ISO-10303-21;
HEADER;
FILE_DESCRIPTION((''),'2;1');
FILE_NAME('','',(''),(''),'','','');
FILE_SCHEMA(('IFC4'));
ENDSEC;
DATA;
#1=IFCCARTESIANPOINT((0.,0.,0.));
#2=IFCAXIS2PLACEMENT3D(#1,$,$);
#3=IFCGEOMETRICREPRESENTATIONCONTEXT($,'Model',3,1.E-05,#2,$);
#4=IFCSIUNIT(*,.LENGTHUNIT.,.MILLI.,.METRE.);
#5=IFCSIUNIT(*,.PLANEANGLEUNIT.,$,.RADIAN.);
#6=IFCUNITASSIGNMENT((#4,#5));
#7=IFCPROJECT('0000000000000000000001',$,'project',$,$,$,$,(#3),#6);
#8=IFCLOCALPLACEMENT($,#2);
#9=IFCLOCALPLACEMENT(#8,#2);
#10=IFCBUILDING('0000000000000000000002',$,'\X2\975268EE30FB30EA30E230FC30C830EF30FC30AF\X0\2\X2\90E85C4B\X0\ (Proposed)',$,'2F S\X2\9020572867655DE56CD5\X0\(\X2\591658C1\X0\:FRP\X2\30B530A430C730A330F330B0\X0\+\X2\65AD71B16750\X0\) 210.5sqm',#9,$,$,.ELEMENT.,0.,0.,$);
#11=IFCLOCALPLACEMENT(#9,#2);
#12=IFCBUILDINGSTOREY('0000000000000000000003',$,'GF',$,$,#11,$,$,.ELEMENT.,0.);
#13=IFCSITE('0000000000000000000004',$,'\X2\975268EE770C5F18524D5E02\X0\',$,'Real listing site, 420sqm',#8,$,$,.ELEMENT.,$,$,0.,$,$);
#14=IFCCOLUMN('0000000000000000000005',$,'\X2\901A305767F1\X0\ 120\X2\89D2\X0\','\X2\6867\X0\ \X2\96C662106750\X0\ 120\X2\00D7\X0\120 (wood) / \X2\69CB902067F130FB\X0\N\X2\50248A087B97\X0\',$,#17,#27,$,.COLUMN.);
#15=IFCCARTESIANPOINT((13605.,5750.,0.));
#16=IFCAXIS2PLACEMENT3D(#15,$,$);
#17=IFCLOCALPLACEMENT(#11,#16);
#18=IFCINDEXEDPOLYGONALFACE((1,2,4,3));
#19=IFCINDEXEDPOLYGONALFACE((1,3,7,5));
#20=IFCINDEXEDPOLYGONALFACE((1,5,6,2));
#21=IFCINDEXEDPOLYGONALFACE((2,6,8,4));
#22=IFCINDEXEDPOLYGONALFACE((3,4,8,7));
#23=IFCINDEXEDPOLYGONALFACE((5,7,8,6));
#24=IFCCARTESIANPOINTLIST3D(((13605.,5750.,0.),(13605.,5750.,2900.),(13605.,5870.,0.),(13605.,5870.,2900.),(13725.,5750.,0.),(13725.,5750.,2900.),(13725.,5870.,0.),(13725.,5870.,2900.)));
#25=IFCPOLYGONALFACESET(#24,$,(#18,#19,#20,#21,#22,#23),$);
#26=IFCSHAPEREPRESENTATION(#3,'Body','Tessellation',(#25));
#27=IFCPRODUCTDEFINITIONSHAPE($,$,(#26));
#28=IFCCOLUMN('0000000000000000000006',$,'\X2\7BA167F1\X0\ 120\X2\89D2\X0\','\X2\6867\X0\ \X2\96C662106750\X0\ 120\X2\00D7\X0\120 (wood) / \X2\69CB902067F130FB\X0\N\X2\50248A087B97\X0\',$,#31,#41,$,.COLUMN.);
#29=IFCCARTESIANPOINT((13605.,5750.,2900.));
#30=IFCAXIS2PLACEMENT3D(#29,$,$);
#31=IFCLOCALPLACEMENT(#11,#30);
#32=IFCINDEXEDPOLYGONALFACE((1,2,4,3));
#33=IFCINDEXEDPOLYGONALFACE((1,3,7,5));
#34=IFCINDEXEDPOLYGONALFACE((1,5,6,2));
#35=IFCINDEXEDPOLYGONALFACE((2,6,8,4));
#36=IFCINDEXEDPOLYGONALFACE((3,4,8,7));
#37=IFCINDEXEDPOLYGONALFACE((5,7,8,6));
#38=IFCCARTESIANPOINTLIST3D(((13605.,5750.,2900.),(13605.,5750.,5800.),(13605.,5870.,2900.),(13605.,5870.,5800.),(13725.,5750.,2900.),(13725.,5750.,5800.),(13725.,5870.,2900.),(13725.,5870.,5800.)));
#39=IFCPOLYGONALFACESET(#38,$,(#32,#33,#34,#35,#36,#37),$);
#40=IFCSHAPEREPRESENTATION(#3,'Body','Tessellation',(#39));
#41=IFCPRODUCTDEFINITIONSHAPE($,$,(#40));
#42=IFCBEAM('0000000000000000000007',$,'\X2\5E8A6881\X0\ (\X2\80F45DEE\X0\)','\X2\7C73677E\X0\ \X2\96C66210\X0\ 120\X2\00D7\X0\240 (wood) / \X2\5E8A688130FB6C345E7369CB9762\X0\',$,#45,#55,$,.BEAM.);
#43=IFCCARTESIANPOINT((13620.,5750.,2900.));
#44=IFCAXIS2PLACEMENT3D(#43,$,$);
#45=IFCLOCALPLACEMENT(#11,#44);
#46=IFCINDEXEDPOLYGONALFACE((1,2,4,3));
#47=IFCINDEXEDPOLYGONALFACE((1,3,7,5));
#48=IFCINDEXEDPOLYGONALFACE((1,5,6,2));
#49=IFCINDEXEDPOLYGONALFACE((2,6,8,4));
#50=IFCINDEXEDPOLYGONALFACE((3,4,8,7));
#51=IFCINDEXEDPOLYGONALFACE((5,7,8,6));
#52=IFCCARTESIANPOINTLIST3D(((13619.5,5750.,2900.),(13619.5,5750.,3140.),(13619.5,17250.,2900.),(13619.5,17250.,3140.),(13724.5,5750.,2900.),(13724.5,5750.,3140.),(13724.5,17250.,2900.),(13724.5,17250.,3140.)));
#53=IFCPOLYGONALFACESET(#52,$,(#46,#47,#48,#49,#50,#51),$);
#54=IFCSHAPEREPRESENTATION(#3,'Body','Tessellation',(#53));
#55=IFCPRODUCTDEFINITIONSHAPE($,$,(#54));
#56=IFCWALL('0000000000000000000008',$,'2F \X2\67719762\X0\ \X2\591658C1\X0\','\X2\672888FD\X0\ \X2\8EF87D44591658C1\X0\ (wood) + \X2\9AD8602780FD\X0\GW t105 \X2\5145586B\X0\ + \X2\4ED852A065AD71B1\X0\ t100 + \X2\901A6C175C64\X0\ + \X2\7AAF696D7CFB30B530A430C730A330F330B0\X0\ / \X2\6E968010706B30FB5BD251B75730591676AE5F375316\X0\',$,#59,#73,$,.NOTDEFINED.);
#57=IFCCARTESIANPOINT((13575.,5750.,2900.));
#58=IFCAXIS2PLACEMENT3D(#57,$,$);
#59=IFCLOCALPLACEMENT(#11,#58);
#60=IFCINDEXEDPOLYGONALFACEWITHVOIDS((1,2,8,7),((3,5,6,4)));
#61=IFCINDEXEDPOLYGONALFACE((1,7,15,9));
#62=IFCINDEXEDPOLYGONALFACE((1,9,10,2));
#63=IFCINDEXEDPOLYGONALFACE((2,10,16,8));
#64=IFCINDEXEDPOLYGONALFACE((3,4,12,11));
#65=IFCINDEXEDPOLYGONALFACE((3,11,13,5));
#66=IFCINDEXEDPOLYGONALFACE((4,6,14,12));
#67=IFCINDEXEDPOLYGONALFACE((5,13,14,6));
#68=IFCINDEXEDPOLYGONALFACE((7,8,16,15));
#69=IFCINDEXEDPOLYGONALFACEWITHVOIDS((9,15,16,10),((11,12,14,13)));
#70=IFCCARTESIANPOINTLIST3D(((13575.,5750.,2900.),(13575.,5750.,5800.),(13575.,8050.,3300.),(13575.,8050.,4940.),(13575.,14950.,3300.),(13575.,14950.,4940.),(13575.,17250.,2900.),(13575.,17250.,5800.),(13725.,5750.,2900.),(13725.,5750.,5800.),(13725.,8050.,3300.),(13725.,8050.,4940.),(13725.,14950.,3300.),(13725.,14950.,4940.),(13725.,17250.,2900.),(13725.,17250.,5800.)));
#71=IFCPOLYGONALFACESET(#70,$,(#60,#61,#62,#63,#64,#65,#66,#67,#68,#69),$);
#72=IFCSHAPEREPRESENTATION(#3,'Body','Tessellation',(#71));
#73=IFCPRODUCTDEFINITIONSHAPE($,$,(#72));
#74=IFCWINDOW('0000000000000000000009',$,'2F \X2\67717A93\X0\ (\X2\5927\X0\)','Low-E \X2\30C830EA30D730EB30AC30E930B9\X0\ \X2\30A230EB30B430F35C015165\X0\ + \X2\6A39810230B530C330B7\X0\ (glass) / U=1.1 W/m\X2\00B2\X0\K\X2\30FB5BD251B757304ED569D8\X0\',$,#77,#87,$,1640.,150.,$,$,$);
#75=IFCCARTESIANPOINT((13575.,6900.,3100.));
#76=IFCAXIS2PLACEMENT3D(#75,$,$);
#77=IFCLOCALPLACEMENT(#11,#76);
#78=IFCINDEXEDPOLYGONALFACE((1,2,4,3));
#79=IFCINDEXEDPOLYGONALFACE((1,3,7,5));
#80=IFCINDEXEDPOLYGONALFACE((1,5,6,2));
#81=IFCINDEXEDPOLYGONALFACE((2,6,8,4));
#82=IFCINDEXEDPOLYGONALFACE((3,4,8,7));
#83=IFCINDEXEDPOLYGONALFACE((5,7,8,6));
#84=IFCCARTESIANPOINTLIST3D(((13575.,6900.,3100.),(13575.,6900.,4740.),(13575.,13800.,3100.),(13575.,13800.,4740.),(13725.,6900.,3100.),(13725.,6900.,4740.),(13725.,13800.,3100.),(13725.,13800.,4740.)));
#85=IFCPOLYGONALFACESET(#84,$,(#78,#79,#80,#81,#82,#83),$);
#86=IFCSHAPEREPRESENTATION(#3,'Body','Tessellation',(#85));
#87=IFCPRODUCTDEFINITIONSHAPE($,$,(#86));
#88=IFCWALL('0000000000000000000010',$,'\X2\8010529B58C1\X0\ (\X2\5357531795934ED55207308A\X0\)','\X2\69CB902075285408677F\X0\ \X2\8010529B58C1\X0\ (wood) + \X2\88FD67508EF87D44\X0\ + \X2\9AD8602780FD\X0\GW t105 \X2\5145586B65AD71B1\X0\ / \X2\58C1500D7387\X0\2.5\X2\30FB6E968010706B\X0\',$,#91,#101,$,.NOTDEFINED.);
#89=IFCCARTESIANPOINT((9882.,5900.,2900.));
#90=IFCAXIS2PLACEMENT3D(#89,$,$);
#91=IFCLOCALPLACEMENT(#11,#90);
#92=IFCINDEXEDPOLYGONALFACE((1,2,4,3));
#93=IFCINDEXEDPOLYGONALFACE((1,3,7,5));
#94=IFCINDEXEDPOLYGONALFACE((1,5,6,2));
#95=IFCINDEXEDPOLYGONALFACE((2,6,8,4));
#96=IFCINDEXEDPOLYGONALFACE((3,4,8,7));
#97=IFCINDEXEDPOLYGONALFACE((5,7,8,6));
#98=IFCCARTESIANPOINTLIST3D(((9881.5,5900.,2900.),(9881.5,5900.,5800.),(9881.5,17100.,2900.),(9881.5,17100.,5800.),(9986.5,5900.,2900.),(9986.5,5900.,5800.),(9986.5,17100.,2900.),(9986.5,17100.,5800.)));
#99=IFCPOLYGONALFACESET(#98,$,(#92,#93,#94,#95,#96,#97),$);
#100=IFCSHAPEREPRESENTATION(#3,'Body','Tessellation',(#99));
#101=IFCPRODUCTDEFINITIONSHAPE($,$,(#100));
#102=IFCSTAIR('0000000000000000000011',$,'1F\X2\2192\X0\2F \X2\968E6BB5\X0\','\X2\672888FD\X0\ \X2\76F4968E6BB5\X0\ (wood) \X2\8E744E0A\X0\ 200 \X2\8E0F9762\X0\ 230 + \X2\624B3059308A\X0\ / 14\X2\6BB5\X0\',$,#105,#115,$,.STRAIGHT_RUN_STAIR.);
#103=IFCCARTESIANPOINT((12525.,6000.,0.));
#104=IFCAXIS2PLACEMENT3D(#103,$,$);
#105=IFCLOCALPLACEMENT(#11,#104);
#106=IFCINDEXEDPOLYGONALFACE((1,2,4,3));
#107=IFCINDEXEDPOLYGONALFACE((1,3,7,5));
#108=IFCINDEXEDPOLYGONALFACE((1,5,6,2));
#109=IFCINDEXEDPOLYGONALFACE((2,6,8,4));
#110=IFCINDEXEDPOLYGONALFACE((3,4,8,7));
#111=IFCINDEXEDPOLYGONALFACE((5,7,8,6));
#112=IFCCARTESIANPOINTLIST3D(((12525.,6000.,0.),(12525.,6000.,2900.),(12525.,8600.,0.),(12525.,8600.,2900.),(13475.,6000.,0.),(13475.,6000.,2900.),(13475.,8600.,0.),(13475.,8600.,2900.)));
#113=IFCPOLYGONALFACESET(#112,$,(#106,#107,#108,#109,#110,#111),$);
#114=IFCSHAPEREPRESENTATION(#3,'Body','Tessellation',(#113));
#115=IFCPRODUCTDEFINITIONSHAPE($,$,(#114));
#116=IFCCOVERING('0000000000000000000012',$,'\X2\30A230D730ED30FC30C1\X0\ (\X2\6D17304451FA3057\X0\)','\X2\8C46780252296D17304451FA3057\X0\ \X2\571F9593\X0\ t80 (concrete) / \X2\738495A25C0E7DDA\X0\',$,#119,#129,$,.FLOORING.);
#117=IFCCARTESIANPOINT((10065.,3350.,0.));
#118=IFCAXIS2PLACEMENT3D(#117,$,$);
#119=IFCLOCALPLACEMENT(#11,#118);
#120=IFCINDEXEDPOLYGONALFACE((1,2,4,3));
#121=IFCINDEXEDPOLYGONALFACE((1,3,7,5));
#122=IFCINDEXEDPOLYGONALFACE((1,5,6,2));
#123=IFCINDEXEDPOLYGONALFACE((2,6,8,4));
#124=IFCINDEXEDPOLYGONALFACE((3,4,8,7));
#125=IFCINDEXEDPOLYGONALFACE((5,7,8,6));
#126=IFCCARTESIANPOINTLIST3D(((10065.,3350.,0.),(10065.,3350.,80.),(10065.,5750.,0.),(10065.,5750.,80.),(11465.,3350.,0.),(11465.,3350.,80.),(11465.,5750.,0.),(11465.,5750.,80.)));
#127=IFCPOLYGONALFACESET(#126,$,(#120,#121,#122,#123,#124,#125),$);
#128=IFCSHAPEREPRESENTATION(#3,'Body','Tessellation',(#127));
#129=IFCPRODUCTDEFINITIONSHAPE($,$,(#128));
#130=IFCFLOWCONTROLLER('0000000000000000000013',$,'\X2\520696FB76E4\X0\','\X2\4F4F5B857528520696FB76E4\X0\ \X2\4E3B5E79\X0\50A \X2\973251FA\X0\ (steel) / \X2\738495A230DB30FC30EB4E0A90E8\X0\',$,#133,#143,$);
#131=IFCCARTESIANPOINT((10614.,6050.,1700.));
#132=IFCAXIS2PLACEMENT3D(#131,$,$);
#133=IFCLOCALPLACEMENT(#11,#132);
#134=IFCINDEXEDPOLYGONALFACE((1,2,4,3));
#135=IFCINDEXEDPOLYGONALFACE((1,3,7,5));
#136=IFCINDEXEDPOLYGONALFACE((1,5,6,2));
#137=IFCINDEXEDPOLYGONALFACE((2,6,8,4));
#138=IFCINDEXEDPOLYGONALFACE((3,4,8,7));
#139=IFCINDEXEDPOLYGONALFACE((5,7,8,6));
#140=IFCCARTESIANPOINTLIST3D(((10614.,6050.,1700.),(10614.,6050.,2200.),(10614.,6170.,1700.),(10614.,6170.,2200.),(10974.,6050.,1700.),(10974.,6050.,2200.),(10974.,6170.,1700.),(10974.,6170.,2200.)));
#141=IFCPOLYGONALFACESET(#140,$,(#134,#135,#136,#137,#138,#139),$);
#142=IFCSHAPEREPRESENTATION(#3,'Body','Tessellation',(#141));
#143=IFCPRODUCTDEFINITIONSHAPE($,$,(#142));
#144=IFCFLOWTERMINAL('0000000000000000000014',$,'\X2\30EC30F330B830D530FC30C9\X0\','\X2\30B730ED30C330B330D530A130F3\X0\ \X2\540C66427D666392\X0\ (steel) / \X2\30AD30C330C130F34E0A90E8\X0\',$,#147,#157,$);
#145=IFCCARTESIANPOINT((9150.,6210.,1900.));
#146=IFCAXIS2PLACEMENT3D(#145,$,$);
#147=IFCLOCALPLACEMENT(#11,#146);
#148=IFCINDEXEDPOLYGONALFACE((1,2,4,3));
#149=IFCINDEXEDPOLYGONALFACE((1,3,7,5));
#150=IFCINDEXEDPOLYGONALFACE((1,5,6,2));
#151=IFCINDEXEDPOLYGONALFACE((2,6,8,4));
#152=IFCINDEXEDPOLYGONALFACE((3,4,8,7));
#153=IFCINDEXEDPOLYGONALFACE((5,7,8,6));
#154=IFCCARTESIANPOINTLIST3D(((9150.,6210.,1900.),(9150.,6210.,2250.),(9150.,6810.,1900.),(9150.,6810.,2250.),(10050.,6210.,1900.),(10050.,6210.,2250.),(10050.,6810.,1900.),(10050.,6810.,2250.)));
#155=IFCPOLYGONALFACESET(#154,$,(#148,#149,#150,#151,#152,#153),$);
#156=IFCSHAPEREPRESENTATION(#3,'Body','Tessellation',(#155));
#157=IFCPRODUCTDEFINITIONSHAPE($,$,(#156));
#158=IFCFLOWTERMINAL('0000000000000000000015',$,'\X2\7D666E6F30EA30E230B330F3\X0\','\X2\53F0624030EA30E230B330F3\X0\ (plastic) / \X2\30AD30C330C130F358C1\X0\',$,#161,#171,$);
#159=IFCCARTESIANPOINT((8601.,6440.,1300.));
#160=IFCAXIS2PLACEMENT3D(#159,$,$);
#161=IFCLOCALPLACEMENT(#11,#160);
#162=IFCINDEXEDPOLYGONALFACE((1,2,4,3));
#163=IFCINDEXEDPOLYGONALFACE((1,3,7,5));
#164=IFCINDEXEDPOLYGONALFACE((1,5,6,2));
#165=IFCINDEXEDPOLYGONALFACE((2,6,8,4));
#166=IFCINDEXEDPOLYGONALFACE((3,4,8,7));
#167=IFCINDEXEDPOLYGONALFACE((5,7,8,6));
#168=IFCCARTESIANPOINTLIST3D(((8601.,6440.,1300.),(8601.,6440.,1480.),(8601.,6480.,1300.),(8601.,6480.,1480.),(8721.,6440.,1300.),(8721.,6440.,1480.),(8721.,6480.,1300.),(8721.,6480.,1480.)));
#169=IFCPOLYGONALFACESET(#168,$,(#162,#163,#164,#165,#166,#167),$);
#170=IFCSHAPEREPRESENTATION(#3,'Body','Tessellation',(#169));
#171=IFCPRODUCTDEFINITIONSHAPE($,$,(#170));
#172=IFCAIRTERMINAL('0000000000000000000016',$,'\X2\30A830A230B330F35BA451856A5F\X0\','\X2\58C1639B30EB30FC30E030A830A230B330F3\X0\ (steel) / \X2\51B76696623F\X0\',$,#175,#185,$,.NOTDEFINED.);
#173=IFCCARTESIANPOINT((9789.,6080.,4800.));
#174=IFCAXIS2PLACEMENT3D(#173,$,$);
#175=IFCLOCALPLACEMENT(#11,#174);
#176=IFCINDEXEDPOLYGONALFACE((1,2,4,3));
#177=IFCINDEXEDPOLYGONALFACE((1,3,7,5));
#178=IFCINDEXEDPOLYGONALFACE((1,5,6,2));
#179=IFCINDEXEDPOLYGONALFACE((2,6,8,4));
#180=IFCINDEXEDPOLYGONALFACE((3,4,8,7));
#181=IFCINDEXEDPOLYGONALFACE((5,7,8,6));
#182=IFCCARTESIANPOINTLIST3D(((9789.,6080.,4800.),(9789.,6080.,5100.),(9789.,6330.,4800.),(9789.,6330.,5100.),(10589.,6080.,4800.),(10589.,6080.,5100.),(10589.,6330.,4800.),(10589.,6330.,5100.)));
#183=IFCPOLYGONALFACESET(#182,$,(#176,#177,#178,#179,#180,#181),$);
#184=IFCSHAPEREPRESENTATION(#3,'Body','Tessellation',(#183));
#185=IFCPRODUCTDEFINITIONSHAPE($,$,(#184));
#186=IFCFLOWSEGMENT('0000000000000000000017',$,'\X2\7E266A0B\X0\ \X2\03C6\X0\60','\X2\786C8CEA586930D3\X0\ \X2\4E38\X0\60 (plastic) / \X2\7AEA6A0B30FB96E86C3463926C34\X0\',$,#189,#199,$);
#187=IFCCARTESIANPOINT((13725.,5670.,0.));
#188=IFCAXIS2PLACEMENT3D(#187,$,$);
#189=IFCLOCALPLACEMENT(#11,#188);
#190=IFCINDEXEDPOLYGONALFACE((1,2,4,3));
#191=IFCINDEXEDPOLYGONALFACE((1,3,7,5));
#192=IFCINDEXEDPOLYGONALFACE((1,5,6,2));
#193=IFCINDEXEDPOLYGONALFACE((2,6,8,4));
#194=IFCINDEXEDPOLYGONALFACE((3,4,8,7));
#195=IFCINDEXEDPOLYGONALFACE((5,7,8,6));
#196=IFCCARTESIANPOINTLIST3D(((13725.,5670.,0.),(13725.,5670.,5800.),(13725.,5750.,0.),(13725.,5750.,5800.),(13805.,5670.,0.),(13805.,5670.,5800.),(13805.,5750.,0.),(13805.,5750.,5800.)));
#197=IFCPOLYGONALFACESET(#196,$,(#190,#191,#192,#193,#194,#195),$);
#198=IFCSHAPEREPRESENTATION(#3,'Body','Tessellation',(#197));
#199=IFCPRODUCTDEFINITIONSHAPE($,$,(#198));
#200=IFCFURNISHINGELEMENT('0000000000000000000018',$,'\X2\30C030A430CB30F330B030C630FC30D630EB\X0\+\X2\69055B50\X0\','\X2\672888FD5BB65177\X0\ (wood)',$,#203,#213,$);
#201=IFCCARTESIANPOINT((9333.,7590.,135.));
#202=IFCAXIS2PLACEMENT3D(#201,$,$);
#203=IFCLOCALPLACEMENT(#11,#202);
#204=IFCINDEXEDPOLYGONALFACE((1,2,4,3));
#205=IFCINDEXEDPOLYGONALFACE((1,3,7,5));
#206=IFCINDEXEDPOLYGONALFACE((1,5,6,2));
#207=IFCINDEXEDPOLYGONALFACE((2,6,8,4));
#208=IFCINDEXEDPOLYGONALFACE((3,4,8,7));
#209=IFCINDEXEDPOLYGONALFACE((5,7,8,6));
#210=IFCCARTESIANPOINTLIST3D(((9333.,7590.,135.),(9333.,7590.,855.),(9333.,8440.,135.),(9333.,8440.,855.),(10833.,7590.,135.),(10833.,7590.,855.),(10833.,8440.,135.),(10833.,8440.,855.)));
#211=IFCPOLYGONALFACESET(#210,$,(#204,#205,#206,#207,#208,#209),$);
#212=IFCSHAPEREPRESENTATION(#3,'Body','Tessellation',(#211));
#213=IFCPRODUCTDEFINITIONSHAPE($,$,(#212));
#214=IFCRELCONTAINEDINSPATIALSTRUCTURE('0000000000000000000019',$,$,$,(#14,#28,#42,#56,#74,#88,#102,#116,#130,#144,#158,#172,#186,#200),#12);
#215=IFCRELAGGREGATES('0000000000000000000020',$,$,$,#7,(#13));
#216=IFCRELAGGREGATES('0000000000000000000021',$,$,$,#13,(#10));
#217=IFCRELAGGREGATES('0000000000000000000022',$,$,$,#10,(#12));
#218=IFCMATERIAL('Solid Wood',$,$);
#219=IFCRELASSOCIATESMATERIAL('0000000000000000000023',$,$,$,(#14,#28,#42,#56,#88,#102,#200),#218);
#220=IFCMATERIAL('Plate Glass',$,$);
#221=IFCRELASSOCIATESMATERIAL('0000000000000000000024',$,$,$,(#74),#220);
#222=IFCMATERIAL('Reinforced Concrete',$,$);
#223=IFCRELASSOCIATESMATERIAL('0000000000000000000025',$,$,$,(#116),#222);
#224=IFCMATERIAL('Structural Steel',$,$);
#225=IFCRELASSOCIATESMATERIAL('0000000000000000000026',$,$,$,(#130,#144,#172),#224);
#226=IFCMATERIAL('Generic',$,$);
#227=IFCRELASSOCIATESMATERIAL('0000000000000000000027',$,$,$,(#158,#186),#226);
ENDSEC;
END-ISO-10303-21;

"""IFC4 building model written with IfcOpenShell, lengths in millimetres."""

from ifc_helpers import new_model, si_unit, frame, frame_2d, origin, place, context, project, spatial, rectangle, extrude, material, element, fill, save


model = new_model("IFC4")

# Units and contexts
model_context = context("Model", 3, precision=1e-05, world=origin())
ifc_project = project(units=[si_unit("LENGTHUNIT", "METRE", prefix="MILLI"), si_unit("PLANEANGLEUNIT", "RADIAN")], contexts=[model_context])

# Site, building, storey
site_placement = place(None, origin())
site = spatial("IfcSite", under=ifc_project, at=site_placement, Name="青森県弘前市", ObjectType="Real listing site, 420sqm", CompositionType="ELEMENT", RefElevation=0.0)
building_placement = place(site_placement, origin())
building = spatial("IfcBuilding", under=site, at=building_placement, Name="青森・リモートワーク2部屋 (Proposed)", ObjectType="2F S造在来工法(外壁:FRPサイディング+断熱材) 210.5sqm", CompositionType="ELEMENT", ElevationOfRefHeight=0.0, ElevationOfTerrain=0.0)
storey_placement = place(building_placement, origin())
storey = spatial("IfcBuildingStorey", under=building, at=storey_placement, Name="GF", CompositionType="ELEMENT", Elevation=0.0)

# Columns
ifc_material_1 = material(Name="Solid Wood")
column_1_placement = place(storey_placement, frame((13605.0, 5750.0, 0.0)))
element("IfcColumn", 1, at=column_1_placement, inside=storey, material=ifc_material_1, Name="通し柱 120角", Description="桧 集成材 120×120 (wood) / 構造柱・N値計算", PredefinedType="COLUMN", context=model_context, shape_type="SweptSolid", body=[
    extrude(rectangle(XDim=120.0, YDim=120.0, at=frame_2d((60.0, 60.0))), frame((13605.0, 5750.0, 0.0)), (0.0, 0.0, 1.0), 2900.0),
])
column_2_placement = place(storey_placement, frame((13605.0, 5750.0, 2900.0)))
element("IfcColumn", 2, at=column_2_placement, inside=storey, material=ifc_material_1, Name="管柱 120角", Description="桧 集成材 120×120 (wood) / 構造柱・N値計算", PredefinedType="COLUMN", context=model_context, shape_type="SweptSolid", body=[
    extrude(rectangle(XDim=120.0, YDim=120.0, at=frame_2d((60.0, 60.0))), frame((13605.0, 5750.0, 2900.0)), (0.0, 0.0, 1.0), 2900.0),
])

# Beam
beam_1_placement = place(storey_placement, frame((13620.0, 5750.0, 2900.0)))
element("IfcBeam", 3, at=beam_1_placement, inside=storey, material=ifc_material_1, Name="床梁 (胴差)", Description="米松 集成 120×240 (wood) / 床梁・水平構面", PredefinedType="BEAM", context=model_context, shape_type="SweptSolid", body=[
    extrude(rectangle(XDim=105.0, YDim=11500.0, at=frame_2d((52.0, 5750.0))), frame((13620.0, 5750.0, 2900.0)), (0.0, 0.0, 1.0), 240.0),
])

# Shared definitions
ifc_material_2 = material(Name="Plate Glass")

# Wall, opening, window
wall_1_placement = place(storey_placement, frame((13575.0, 5750.0, 2900.0)))
wall_1 = element("IfcWall", 4, at=wall_1_placement, inside=storey, material=ifc_material_1, Name="2F 東面 外壁", Description="木製 軸組外壁 (wood) + 高性能GW t105 充填 + 付加断熱 t100 + 通気層 + 窯業系サイディング / 準耐火・寒冷地外皮強化", PredefinedType="NOTDEFINED", context=model_context, shape_type="SweptSolid", body=[
    extrude(rectangle(XDim=150.0, YDim=11500.0, at=frame_2d((75.0, 5750.0))), frame((13575.0, 5750.0, 2900.0)), (0.0, 0.0, 1.0), 2900.0),
])
opening_1_placement = place(storey_placement, frame((13575.0, 6900.0, 3100.0)))
opening_1 = element("IfcOpeningElement", 5, at=opening_1_placement, cuts=wall_1, PredefinedType="NOTDEFINED", context=model_context, shape_type="SweptSolid", body=[
    extrude(rectangle(XDim=150.0, YDim=6900.0, at=frame_2d((75.0, 3450.0))), frame((13575.0, 6900.0, 3100.0)), (0.0, 0.0, 1.0), 1640.0),
])
window_1_placement = place(storey_placement, frame((13575.0, 6900.0, 3100.0)))
window_1 = element("IfcWindow", 6, at=window_1_placement, inside=storey, material=ifc_material_2, Name="2F 東窓 (大)", Description="Low-E トリプルガラス アルゴン封入 + 樹脂サッシ (glass) / U=1.1 W/m²K・寒冷地仕様", OverallHeight=1640.0, OverallWidth=150.0, context=model_context, shape_type="SweptSolid", body=[
    extrude(rectangle(XDim=150.0, YDim=6900.0, at=frame_2d((75.0, 3450.0))), frame((13575.0, 6900.0, 3100.0)), (0.0, 0.0, 1.0), 1640.0),
])
fill(opening_1, window_1)

# Wall
wall_2_placement = place(storey_placement, frame((9882.0, 5900.0, 2900.0)))
element("IfcWall", 7, at=wall_2_placement, inside=storey, material=ifc_material_1, Name="耐力壁 (南北間仕切り)", Description="構造用合板 耐力壁 (wood) + 製材軸組 + 高性能GW t105 充填断熱 / 壁倍率2.5・準耐火", PredefinedType="NOTDEFINED", context=model_context, shape_type="SweptSolid", body=[
    extrude(rectangle(XDim=105.0, YDim=11200.0, at=frame_2d((52.0, 5600.0))), frame((9882.0, 5900.0, 2900.0)), (0.0, 0.0, 1.0), 2900.0),
])

# Stair
stair_placement = place(storey_placement, frame((12525.0, 6000.0, 0.0)))
element("IfcStair", 8, at=stair_placement, inside=storey, material=ifc_material_1, Name="1F→2F 階段", Description="木製 直階段 (wood) 蹴上 200 踏面 230 + 手すり / 14段", PredefinedType="STRAIGHT_RUN_STAIR", context=model_context, shape_type="SweptSolid", body=[
    extrude(rectangle(XDim=950.0, YDim=2600.0, at=frame_2d((475.0, 1300.0))), frame((12525.0, 6000.0, 0.0)), (0.0, 0.0, 1.0), 2900.0),
])

# Covering
ifc_material_3 = material(Name="Reinforced Concrete")
covering_placement = place(storey_placement, frame((10065.0, 3350.0, 0.0)))
element("IfcCovering", 9, at=covering_placement, inside=storey, material=ifc_material_3, Name="アプローチ (洗い出し)", Description="豆砂利洗い出し 土間 t80 (concrete) / 玄関導線", PredefinedType="FLOORING", context=model_context, shape_type="SweptSolid", body=[
    extrude(rectangle(XDim=1400.0, YDim=2400.0, at=frame_2d((700.0, 1200.0))), frame((10065.0, 3350.0, 0.0)), (0.0, 0.0, 1.0), 80.0),
])

# Flow controller
ifc_material_4 = material(Name="Structural Steel")
flow_controller_placement = place(storey_placement, frame((10614.0, 6050.0, 1700.0)))
element("IfcFlowController", 10, at=flow_controller_placement, inside=storey, material=ifc_material_4, Name="分電盤", Description="住宅用分電盤 主幹50A 露出 (steel) / 玄関ホール上部", context=model_context, shape_type="SweptSolid", body=[
    extrude(rectangle(XDim=360.0, YDim=120.0, at=frame_2d((180.0, 60.0))), frame((10614.0, 6050.0, 1700.0)), (0.0, 0.0, 1.0), 500.0),
])

# Flow terminals
flow_terminal_1_placement = place(storey_placement, frame((9150.0, 6210.0, 1900.0)))
element("IfcFlowTerminal", 11, at=flow_terminal_1_placement, inside=storey, material=ifc_material_4, Name="レンジフード", Description="シロッコファン 同時給排 (steel) / キッチン上部", context=model_context, shape_type="SweptSolid", body=[
    extrude(rectangle(XDim=900.0, YDim=600.0, at=frame_2d((450.0, 300.0))), frame((9150.0, 6210.0, 1900.0)), (0.0, 0.0, 1.0), 350.0),
])
ifc_material_5 = material(Name="Generic")
flow_terminal_2_placement = place(storey_placement, frame((8601.0, 6440.0, 1300.0)))
element("IfcFlowTerminal", 12, at=flow_terminal_2_placement, inside=storey, material=ifc_material_5, Name="給湯リモコン", Description="台所リモコン (plastic) / キッチン壁", context=model_context, shape_type="SweptSolid", body=[
    extrude(rectangle(XDim=120.0, YDim=40.0, at=frame_2d((60.0, 20.0))), frame((8601.0, 6440.0, 1300.0)), (0.0, 0.0, 1.0), 180.0),
])

# Air terminal
air_terminal_placement = place(storey_placement, frame((9789.0, 6080.0, 4800.0)))
element("IfcAirTerminal", 13, at=air_terminal_placement, inside=storey, material=ifc_material_4, Name="エアコン室内機", Description="壁掛ルームエアコン (steel) / 冷暖房", PredefinedType="NOTDEFINED", context=model_context, shape_type="SweptSolid", body=[
    extrude(rectangle(XDim=800.0, YDim=250.0, at=frame_2d((400.0, 125.0))), frame((9789.0, 6080.0, 4800.0)), (0.0, 0.0, 1.0), 300.0),
])

# Flow segment
flow_segment_placement = place(storey_placement, frame((13725.0, 5670.0, 0.0)))
element("IfcFlowSegment", 14, at=flow_segment_placement, inside=storey, material=ifc_material_5, Name="縦樋 φ60", Description="硬質塩ビ 丸60 (plastic) / 竪樋・雨水排水", context=model_context, shape_type="SweptSolid", body=[
    extrude(rectangle(XDim=80.0, YDim=80.0, at=frame_2d((40.0, 40.0))), frame((13725.0, 5670.0, 0.0)), (0.0, 0.0, 1.0), 5800.0),
])

# Furnishing element
furnishing_1_placement = place(storey_placement, frame((9333.0, 7590.0, 135.0)))
element("IfcFurnishingElement", 15, at=furnishing_1_placement, inside=storey, material=ifc_material_1, Name="ダイニングテーブル+椅子", Description="木製家具 (wood)", context=model_context, shape_type="SweptSolid", body=[
    extrude(rectangle(XDim=1500.0, YDim=850.0, at=frame_2d((750.0, 425.0))), frame((9333.0, 7590.0, 135.0)), (0.0, 0.0, 1.0), 720.0),
])

save(model, "model.ifc")
